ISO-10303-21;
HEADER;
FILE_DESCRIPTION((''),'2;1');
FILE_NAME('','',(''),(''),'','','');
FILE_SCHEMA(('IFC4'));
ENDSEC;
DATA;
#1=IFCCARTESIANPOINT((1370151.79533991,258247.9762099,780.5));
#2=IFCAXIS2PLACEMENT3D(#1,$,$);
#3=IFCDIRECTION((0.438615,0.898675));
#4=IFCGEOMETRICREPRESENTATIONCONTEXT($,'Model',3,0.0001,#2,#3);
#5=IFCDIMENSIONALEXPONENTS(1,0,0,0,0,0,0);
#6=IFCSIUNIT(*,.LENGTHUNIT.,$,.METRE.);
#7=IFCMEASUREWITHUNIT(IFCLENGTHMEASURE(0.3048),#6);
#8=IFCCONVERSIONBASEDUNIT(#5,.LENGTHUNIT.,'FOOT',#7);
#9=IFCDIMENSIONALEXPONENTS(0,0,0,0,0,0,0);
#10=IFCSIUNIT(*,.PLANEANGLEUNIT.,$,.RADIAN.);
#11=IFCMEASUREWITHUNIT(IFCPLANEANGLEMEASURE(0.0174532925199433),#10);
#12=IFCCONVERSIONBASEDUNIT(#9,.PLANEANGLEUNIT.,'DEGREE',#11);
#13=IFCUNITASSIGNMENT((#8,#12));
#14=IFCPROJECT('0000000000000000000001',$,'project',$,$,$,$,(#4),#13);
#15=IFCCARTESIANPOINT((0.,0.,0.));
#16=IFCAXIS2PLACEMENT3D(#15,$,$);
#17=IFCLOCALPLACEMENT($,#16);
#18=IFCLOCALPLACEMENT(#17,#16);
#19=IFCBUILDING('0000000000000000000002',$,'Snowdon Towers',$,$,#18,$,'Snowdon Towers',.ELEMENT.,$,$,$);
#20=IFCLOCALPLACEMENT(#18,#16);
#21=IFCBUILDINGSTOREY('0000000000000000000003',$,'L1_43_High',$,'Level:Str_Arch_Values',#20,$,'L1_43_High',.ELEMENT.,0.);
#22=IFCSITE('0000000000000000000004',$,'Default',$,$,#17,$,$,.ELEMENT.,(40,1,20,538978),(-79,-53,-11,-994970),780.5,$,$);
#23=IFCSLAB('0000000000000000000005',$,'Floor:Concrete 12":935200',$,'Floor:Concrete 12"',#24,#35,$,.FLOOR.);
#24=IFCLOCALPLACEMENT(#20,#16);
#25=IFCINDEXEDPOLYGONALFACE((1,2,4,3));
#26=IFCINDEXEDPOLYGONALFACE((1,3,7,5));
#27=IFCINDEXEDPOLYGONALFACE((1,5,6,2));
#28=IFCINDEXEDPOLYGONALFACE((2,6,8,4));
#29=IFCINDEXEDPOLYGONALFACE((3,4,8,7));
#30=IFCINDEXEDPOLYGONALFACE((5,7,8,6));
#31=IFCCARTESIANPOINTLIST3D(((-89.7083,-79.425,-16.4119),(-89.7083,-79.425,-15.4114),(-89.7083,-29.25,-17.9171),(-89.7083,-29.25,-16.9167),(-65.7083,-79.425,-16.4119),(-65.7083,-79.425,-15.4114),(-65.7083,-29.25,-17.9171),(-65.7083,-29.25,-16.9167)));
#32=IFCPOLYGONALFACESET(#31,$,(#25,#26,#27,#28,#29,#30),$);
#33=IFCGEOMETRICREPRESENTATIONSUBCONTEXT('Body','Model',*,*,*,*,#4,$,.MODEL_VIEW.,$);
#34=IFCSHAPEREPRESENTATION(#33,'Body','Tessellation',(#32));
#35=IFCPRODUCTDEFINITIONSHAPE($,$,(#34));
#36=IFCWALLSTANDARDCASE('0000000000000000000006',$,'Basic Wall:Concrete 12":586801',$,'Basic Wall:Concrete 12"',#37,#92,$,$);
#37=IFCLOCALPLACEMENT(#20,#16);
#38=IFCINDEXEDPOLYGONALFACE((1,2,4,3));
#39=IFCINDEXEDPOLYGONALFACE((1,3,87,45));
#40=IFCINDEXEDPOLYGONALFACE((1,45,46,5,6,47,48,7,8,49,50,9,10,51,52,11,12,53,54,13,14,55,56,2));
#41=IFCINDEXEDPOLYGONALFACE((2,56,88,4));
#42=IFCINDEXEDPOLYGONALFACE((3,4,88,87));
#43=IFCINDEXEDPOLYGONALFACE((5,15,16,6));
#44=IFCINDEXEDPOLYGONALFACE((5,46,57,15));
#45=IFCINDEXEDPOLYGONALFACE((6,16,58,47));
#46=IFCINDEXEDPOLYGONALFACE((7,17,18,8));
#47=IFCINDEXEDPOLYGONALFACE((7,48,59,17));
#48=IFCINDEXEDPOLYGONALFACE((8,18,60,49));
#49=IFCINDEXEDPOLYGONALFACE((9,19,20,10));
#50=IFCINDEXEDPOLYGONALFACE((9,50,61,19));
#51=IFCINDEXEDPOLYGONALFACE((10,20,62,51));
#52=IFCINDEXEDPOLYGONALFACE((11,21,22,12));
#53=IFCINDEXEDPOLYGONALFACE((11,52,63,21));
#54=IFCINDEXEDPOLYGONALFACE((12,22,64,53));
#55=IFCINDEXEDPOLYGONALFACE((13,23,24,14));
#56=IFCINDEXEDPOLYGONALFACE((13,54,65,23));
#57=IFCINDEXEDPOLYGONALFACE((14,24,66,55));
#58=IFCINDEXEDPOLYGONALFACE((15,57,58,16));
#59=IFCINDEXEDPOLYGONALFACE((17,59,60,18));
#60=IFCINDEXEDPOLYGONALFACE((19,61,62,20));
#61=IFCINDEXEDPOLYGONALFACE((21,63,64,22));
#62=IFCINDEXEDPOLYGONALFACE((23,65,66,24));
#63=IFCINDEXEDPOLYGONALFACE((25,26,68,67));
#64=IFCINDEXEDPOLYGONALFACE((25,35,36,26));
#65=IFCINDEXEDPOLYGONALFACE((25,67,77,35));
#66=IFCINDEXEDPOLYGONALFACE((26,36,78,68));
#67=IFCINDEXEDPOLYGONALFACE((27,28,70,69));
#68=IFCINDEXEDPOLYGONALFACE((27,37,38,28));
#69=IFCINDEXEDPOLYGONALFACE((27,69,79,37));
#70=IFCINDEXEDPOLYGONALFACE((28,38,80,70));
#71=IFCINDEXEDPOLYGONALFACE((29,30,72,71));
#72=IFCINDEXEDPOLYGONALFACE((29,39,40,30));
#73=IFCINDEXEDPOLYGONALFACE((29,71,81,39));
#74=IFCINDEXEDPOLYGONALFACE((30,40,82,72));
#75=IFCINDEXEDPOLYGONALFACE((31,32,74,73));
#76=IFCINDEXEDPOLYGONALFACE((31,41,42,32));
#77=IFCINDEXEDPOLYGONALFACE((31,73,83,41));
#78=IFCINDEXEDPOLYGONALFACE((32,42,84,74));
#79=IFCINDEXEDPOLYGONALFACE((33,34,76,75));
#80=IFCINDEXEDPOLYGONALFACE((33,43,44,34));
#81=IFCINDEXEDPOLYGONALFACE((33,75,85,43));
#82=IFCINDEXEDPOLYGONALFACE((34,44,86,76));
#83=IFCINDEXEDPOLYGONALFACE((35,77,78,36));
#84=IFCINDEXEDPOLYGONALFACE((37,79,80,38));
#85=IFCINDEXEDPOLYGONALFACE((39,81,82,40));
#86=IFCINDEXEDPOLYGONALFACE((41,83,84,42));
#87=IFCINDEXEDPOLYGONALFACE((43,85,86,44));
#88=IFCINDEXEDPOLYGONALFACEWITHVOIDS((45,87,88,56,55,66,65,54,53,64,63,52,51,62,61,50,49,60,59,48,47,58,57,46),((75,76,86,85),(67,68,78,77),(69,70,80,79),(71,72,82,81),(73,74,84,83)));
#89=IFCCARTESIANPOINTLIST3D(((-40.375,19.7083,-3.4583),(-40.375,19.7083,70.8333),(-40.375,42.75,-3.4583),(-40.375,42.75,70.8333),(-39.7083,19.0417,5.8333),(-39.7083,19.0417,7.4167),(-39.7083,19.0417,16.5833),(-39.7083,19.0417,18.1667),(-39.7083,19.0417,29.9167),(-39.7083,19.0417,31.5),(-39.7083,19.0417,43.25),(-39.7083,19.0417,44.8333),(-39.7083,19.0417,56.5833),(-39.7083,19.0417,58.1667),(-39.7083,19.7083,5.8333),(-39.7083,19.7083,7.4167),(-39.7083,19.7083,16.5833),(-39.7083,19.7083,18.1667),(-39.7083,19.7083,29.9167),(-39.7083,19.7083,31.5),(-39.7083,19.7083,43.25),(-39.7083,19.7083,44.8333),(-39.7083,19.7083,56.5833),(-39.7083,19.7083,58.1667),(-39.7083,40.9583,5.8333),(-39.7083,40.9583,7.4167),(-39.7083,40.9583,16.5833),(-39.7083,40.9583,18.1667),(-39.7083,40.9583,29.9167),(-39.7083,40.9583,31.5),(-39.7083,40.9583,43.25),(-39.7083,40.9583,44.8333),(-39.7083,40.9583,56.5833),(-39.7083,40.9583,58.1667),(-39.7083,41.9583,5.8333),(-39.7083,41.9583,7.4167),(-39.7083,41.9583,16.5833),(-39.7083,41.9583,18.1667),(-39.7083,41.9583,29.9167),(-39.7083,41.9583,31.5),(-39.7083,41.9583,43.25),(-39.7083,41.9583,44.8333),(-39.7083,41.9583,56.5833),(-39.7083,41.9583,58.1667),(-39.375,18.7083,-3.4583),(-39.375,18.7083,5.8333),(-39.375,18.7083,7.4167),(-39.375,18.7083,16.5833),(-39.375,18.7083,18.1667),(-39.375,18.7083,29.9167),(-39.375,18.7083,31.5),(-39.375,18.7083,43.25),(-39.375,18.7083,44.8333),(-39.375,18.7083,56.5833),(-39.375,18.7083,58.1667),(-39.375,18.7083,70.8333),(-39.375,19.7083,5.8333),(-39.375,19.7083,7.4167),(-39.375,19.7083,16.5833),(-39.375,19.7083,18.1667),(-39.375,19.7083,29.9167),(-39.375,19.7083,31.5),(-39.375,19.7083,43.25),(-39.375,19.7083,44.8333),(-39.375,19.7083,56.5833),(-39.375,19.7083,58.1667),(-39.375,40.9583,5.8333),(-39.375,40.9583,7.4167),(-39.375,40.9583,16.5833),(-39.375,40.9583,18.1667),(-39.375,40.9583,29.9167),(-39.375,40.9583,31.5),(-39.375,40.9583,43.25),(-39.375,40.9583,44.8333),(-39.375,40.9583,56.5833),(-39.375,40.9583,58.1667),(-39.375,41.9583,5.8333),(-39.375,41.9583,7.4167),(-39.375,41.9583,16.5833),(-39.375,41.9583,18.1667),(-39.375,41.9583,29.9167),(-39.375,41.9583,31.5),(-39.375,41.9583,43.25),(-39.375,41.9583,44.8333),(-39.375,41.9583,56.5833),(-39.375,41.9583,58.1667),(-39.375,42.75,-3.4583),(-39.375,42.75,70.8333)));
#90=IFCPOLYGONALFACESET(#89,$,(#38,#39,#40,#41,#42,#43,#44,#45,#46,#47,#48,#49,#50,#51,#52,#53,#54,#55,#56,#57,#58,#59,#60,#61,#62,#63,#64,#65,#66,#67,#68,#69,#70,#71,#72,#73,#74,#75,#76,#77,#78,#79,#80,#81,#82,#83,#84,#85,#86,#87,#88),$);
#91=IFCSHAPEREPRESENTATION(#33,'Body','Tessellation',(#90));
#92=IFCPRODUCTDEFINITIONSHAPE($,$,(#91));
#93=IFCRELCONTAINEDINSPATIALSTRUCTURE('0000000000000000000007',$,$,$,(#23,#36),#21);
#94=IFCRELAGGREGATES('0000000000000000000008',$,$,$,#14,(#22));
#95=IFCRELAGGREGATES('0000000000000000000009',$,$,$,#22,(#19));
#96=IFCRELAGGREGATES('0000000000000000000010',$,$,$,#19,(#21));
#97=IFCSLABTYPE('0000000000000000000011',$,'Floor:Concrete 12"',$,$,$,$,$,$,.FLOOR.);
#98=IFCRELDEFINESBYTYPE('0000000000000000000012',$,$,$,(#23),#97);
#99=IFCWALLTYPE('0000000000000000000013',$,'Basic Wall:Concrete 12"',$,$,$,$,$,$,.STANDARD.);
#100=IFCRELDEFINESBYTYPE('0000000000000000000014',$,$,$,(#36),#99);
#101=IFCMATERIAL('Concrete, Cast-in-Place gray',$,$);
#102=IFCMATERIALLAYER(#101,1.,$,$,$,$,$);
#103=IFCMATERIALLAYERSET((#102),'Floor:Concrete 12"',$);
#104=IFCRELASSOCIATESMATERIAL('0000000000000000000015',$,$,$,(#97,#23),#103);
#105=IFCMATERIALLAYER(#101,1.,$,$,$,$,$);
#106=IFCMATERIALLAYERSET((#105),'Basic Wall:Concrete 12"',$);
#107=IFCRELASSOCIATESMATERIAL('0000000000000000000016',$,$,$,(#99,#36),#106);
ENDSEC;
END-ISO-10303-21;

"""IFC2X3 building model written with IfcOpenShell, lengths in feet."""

from ifc_helpers import new_model, entity, si_unit, converted_unit, direction, frame, frame_2d, origin, origin_2d_with_axis, place, context, subcontext, project, spatial, polyline, rectangle, outline, extrude, clip, halfspace, material, layer, layer_set, layer_usage, type_object, element, save


model = new_model("IFC2X3")

# Units and contexts
model_context = context("Model", 3, precision=0.0001, world=frame((1370151.79533991, 258247.9762099, 780.5)), true_north=direction((0.438615, 0.898675)))
body_context = subcontext(model_context, "Body", "Model", "MODEL_VIEW")
ifc_project = project(units=[converted_unit("LENGTHUNIT", "FOOT", entity("IfcLengthMeasure", 0.3048), si_unit("LENGTHUNIT", "METRE"), dimensions=[1, 0, 0, 0, 0, 0, 0]), converted_unit("PLANEANGLEUNIT", "DEGREE", entity("IfcPlaneAngleMeasure", 0.0174532925199433), si_unit("PLANEANGLEUNIT", "RADIAN"), dimensions=[0, 0, 0, 0, 0, 0, 0])], contexts=[model_context])

# Site, building, storey
site_placement = place(None, origin())
site = spatial("IfcSite", under=ifc_project, at=site_placement, Name="Default", CompositionType="ELEMENT", RefLatitude=(40, 1, 20, 538978), RefLongitude=(-79, -53, -11, -994970), RefElevation=780.5)
building_placement = place(site_placement, origin())
building = spatial("IfcBuilding", under=site, at=building_placement, Name="Snowdon Towers", LongName="Snowdon Towers", CompositionType="ELEMENT")
storey_placement = place(building_placement, origin())
storey = spatial("IfcBuildingStorey", under=building, at=storey_placement, Name="L1_43_High", ObjectType="Level:Str_Arch_Values", LongName="L1_43_High", CompositionType="ELEMENT", Elevation=0.0)

# Slab
ifc_material_1 = material(Name="Concrete, Cast-in-Place gray")
ifc_layer_1 = layer(ifc_material_1, 1.0)
ifc_layer_set_1 = layer_set([ifc_layer_1], Name="Floor:Concrete 12\"")
ifc_layer_usage_1 = layer_usage(ifc_layer_set_1, "AXIS3", "POSITIVE", 0.0)
slab_type_1 = type_object("IfcSlabType", Name="Floor:Concrete 12\"", PredefinedType="FLOOR", material=ifc_layer_set_1)
slab_1_placement = place(storey_placement, origin())
element("IfcSlab", 1, at=slab_1_placement, inside=storey, type_object=slab_type_1, material=ifc_layer_usage_1, Name="Floor:Concrete 12\":935200", ObjectType="Floor:Concrete 12\"", PredefinedType="FLOOR", context=body_context, shape_type="SweptSolid", body=[
    clip(clip(extrude(rectangle(XDim=50.1976, YDim=24.0, at=frame_2d((0.0, 0.0), x_axis=(1.0, 0.0))), frame((-77.7083, -54.3375, -16.164), z_axis=(0.0, -0.029987, -0.99955), x_axis=(0.0, 0.99955, -0.029987)), (0.029987, 0.0, 0.99955), 1.0009), halfspace(frame((-77.7083, -29.25, -17.9171), z_axis=(0.0, -0.029987, -0.99955), x_axis=(0.0, -0.99955, 0.029987)), False)), halfspace(frame((-77.7083, -29.25, -16.9167), z_axis=(0.0, 0.029987, 0.99955), x_axis=(0.0, 0.99955, -0.029987)), False)),
])

# Wall, openings
ifc_layer_2 = layer(ifc_material_1, 1.0)
ifc_layer_set_2 = layer_set([ifc_layer_2], Name="Basic Wall:Concrete 12\"")
ifc_layer_usage_2 = layer_usage(ifc_layer_set_2, "AXIS2", "NEGATIVE", 0.5)
wall_type = type_object("IfcWallType", Name="Basic Wall:Concrete 12\"", PredefinedType="STANDARD", material=ifc_layer_set_2)
wall_1_placement = place(storey_placement, frame((-39.875, 18.7083, -3.4583), z_axis=(0.0, 0.0, 1.0), x_axis=(0.0, 1.0, 0.0)))
wall_1 = element("IfcWallStandardCase", 2, at=wall_1_placement, inside=storey, type_object=wall_type, material=ifc_layer_usage_2, Name="Basic Wall:Concrete 12\":586801", ObjectType="Basic Wall:Concrete 12\"", context=body_context, shape_type="SweptSolid", body=[
    extrude(outline(polyline([(24.0417, -0.5), (24.0417, 0.5), (1.0, 0.5), (0.0, -0.5), (24.0417, -0.5)])), origin(), (0.0, 0.0, 1.0), 74.2917),
])
opening_1_placement = place(wall_1_placement, origin())
element("IfcOpeningElement", 3, at=opening_1_placement, cuts=wall_1, ObjectType="Recess", context=body_context, shape_type="SweptSolid", body=[
    extrude(rectangle(XDim=1.5833, YDim=1.0, at=origin_2d_with_axis()), frame((0.5, -0.5, 10.0833), z_axis=(0.0, 1.0, 0.0), x_axis=(0.0, 0.0, -1.0)), (0.0, 0.0, 1.0), 0.3333),
])
opening_2_placement = place(wall_1_placement, origin())
element("IfcOpeningElement", 4, at=opening_2_placement, cuts=wall_1, ObjectType="Recess", context=body_context, shape_type="SweptSolid", body=[
    extrude(rectangle(XDim=1.5833, YDim=1.0, at=frame_2d((0.0, 0.0), x_axis=(1.0, 0.0))), frame((0.5, -0.5, 20.8333), z_axis=(0.0, 1.0, 0.0), x_axis=(0.0, 0.0, -1.0)), (0.0, 0.0, 1.0), 0.3333),
])
opening_3_placement = place(wall_1_placement, origin())
element("IfcOpeningElement", 5, at=opening_3_placement, cuts=wall_1, ObjectType="Recess", context=body_context, shape_type="SweptSolid", body=[
    extrude(rectangle(XDim=1.5833, YDim=1.0, at=frame_2d((0.0, 0.0), x_axis=(1.0, 0.0))), frame((0.5, -0.5, 34.1667), z_axis=(0.0, 1.0, 0.0), x_axis=(0.0, 0.0, -1.0)), (0.0, 0.0, 1.0), 0.3333),
])
opening_4_placement = place(wall_1_placement, origin())
element("IfcOpeningElement", 6, at=opening_4_placement, cuts=wall_1, ObjectType="Recess", context=body_context, shape_type="SweptSolid", body=[
    extrude(rectangle(XDim=1.5833, YDim=1.0, at=origin_2d_with_axis()), frame((0.5, -0.5, 47.5), z_axis=(0.0, 1.0, 0.0), x_axis=(0.0, 0.0, -1.0)), (0.0, 0.0, 1.0), 0.3333),
])
opening_5_placement = place(wall_1_placement, origin())
element("IfcOpeningElement", 7, at=opening_5_placement, cuts=wall_1, ObjectType="Recess", context=body_context, shape_type="SweptSolid", body=[
    extrude(rectangle(XDim=1.5833, YDim=1.0, at=frame_2d((0.0, 0.0), x_axis=(1.0, 0.0))), frame((0.5, -0.5, 60.8333), z_axis=(0.0, 1.0, 0.0), x_axis=(0.0, 0.0, -1.0)), (0.0, 0.0, 1.0), 0.3333),
])
opening_6_placement = place(wall_1_placement, origin())
element("IfcOpeningElement", 8, at=opening_6_placement, cuts=wall_1, ObjectType="Recess", context=body_context, shape_type="SweptSolid", body=[
    extrude(rectangle(XDim=1.5833, YDim=1.0, at=frame_2d((0.0, 0.0), x_axis=(1.0, 0.0))), frame((22.75, -0.5, 20.8333), z_axis=(0.0, 1.0, 0.0), x_axis=(0.0, 0.0, -1.0)), (0.0, 0.0, 1.0), 0.3333),
])
opening_7_placement = place(wall_1_placement, origin())
element("IfcOpeningElement", 9, at=opening_7_placement, cuts=wall_1, ObjectType="Recess", context=body_context, shape_type="SweptSolid", body=[
    extrude(rectangle(XDim=1.5833, YDim=1.0, at=frame_2d((0.0, 0.0), x_axis=(1.0, 0.0))), frame((22.75, -0.5, 10.0833), z_axis=(0.0, 1.0, 0.0), x_axis=(0.0, 0.0, -1.0)), (0.0, 0.0, 1.0), 0.3333),
])
opening_8_placement = place(wall_1_placement, origin())
element("IfcOpeningElement", 10, at=opening_8_placement, cuts=wall_1, ObjectType="Recess", context=body_context, shape_type="SweptSolid", body=[
    extrude(rectangle(XDim=1.5833, YDim=1.0, at=frame_2d((0.0, 0.0), x_axis=(1.0, 0.0))), frame((22.75, -0.5, 34.1667), z_axis=(0.0, 1.0, 0.0), x_axis=(0.0, 0.0, -1.0)), (0.0, 0.0, 1.0), 0.3333),
])
opening_9_placement = place(wall_1_placement, origin())
element("IfcOpeningElement", 11, at=opening_9_placement, cuts=wall_1, ObjectType="Recess", context=body_context, shape_type="SweptSolid", body=[
    extrude(rectangle(XDim=1.5833, YDim=1.0, at=origin_2d_with_axis()), frame((22.75, -0.5, 47.5), z_axis=(0.0, 1.0, 0.0), x_axis=(0.0, 0.0, -1.0)), (0.0, 0.0, 1.0), 0.3333),
])
opening_10_placement = place(wall_1_placement, origin())
element("IfcOpeningElement", 12, at=opening_10_placement, cuts=wall_1, ObjectType="Recess", context=body_context, shape_type="SweptSolid", body=[
    extrude(rectangle(XDim=1.5833, YDim=1.0, at=frame_2d((0.0, 0.0), x_axis=(1.0, 0.0))), frame((22.75, -0.5, 60.8333), z_axis=(0.0, 1.0, 0.0), x_axis=(0.0, 0.0, -1.0)), (0.0, 0.0, 1.0), 0.3333),
])

save(model, "model.ifc")
